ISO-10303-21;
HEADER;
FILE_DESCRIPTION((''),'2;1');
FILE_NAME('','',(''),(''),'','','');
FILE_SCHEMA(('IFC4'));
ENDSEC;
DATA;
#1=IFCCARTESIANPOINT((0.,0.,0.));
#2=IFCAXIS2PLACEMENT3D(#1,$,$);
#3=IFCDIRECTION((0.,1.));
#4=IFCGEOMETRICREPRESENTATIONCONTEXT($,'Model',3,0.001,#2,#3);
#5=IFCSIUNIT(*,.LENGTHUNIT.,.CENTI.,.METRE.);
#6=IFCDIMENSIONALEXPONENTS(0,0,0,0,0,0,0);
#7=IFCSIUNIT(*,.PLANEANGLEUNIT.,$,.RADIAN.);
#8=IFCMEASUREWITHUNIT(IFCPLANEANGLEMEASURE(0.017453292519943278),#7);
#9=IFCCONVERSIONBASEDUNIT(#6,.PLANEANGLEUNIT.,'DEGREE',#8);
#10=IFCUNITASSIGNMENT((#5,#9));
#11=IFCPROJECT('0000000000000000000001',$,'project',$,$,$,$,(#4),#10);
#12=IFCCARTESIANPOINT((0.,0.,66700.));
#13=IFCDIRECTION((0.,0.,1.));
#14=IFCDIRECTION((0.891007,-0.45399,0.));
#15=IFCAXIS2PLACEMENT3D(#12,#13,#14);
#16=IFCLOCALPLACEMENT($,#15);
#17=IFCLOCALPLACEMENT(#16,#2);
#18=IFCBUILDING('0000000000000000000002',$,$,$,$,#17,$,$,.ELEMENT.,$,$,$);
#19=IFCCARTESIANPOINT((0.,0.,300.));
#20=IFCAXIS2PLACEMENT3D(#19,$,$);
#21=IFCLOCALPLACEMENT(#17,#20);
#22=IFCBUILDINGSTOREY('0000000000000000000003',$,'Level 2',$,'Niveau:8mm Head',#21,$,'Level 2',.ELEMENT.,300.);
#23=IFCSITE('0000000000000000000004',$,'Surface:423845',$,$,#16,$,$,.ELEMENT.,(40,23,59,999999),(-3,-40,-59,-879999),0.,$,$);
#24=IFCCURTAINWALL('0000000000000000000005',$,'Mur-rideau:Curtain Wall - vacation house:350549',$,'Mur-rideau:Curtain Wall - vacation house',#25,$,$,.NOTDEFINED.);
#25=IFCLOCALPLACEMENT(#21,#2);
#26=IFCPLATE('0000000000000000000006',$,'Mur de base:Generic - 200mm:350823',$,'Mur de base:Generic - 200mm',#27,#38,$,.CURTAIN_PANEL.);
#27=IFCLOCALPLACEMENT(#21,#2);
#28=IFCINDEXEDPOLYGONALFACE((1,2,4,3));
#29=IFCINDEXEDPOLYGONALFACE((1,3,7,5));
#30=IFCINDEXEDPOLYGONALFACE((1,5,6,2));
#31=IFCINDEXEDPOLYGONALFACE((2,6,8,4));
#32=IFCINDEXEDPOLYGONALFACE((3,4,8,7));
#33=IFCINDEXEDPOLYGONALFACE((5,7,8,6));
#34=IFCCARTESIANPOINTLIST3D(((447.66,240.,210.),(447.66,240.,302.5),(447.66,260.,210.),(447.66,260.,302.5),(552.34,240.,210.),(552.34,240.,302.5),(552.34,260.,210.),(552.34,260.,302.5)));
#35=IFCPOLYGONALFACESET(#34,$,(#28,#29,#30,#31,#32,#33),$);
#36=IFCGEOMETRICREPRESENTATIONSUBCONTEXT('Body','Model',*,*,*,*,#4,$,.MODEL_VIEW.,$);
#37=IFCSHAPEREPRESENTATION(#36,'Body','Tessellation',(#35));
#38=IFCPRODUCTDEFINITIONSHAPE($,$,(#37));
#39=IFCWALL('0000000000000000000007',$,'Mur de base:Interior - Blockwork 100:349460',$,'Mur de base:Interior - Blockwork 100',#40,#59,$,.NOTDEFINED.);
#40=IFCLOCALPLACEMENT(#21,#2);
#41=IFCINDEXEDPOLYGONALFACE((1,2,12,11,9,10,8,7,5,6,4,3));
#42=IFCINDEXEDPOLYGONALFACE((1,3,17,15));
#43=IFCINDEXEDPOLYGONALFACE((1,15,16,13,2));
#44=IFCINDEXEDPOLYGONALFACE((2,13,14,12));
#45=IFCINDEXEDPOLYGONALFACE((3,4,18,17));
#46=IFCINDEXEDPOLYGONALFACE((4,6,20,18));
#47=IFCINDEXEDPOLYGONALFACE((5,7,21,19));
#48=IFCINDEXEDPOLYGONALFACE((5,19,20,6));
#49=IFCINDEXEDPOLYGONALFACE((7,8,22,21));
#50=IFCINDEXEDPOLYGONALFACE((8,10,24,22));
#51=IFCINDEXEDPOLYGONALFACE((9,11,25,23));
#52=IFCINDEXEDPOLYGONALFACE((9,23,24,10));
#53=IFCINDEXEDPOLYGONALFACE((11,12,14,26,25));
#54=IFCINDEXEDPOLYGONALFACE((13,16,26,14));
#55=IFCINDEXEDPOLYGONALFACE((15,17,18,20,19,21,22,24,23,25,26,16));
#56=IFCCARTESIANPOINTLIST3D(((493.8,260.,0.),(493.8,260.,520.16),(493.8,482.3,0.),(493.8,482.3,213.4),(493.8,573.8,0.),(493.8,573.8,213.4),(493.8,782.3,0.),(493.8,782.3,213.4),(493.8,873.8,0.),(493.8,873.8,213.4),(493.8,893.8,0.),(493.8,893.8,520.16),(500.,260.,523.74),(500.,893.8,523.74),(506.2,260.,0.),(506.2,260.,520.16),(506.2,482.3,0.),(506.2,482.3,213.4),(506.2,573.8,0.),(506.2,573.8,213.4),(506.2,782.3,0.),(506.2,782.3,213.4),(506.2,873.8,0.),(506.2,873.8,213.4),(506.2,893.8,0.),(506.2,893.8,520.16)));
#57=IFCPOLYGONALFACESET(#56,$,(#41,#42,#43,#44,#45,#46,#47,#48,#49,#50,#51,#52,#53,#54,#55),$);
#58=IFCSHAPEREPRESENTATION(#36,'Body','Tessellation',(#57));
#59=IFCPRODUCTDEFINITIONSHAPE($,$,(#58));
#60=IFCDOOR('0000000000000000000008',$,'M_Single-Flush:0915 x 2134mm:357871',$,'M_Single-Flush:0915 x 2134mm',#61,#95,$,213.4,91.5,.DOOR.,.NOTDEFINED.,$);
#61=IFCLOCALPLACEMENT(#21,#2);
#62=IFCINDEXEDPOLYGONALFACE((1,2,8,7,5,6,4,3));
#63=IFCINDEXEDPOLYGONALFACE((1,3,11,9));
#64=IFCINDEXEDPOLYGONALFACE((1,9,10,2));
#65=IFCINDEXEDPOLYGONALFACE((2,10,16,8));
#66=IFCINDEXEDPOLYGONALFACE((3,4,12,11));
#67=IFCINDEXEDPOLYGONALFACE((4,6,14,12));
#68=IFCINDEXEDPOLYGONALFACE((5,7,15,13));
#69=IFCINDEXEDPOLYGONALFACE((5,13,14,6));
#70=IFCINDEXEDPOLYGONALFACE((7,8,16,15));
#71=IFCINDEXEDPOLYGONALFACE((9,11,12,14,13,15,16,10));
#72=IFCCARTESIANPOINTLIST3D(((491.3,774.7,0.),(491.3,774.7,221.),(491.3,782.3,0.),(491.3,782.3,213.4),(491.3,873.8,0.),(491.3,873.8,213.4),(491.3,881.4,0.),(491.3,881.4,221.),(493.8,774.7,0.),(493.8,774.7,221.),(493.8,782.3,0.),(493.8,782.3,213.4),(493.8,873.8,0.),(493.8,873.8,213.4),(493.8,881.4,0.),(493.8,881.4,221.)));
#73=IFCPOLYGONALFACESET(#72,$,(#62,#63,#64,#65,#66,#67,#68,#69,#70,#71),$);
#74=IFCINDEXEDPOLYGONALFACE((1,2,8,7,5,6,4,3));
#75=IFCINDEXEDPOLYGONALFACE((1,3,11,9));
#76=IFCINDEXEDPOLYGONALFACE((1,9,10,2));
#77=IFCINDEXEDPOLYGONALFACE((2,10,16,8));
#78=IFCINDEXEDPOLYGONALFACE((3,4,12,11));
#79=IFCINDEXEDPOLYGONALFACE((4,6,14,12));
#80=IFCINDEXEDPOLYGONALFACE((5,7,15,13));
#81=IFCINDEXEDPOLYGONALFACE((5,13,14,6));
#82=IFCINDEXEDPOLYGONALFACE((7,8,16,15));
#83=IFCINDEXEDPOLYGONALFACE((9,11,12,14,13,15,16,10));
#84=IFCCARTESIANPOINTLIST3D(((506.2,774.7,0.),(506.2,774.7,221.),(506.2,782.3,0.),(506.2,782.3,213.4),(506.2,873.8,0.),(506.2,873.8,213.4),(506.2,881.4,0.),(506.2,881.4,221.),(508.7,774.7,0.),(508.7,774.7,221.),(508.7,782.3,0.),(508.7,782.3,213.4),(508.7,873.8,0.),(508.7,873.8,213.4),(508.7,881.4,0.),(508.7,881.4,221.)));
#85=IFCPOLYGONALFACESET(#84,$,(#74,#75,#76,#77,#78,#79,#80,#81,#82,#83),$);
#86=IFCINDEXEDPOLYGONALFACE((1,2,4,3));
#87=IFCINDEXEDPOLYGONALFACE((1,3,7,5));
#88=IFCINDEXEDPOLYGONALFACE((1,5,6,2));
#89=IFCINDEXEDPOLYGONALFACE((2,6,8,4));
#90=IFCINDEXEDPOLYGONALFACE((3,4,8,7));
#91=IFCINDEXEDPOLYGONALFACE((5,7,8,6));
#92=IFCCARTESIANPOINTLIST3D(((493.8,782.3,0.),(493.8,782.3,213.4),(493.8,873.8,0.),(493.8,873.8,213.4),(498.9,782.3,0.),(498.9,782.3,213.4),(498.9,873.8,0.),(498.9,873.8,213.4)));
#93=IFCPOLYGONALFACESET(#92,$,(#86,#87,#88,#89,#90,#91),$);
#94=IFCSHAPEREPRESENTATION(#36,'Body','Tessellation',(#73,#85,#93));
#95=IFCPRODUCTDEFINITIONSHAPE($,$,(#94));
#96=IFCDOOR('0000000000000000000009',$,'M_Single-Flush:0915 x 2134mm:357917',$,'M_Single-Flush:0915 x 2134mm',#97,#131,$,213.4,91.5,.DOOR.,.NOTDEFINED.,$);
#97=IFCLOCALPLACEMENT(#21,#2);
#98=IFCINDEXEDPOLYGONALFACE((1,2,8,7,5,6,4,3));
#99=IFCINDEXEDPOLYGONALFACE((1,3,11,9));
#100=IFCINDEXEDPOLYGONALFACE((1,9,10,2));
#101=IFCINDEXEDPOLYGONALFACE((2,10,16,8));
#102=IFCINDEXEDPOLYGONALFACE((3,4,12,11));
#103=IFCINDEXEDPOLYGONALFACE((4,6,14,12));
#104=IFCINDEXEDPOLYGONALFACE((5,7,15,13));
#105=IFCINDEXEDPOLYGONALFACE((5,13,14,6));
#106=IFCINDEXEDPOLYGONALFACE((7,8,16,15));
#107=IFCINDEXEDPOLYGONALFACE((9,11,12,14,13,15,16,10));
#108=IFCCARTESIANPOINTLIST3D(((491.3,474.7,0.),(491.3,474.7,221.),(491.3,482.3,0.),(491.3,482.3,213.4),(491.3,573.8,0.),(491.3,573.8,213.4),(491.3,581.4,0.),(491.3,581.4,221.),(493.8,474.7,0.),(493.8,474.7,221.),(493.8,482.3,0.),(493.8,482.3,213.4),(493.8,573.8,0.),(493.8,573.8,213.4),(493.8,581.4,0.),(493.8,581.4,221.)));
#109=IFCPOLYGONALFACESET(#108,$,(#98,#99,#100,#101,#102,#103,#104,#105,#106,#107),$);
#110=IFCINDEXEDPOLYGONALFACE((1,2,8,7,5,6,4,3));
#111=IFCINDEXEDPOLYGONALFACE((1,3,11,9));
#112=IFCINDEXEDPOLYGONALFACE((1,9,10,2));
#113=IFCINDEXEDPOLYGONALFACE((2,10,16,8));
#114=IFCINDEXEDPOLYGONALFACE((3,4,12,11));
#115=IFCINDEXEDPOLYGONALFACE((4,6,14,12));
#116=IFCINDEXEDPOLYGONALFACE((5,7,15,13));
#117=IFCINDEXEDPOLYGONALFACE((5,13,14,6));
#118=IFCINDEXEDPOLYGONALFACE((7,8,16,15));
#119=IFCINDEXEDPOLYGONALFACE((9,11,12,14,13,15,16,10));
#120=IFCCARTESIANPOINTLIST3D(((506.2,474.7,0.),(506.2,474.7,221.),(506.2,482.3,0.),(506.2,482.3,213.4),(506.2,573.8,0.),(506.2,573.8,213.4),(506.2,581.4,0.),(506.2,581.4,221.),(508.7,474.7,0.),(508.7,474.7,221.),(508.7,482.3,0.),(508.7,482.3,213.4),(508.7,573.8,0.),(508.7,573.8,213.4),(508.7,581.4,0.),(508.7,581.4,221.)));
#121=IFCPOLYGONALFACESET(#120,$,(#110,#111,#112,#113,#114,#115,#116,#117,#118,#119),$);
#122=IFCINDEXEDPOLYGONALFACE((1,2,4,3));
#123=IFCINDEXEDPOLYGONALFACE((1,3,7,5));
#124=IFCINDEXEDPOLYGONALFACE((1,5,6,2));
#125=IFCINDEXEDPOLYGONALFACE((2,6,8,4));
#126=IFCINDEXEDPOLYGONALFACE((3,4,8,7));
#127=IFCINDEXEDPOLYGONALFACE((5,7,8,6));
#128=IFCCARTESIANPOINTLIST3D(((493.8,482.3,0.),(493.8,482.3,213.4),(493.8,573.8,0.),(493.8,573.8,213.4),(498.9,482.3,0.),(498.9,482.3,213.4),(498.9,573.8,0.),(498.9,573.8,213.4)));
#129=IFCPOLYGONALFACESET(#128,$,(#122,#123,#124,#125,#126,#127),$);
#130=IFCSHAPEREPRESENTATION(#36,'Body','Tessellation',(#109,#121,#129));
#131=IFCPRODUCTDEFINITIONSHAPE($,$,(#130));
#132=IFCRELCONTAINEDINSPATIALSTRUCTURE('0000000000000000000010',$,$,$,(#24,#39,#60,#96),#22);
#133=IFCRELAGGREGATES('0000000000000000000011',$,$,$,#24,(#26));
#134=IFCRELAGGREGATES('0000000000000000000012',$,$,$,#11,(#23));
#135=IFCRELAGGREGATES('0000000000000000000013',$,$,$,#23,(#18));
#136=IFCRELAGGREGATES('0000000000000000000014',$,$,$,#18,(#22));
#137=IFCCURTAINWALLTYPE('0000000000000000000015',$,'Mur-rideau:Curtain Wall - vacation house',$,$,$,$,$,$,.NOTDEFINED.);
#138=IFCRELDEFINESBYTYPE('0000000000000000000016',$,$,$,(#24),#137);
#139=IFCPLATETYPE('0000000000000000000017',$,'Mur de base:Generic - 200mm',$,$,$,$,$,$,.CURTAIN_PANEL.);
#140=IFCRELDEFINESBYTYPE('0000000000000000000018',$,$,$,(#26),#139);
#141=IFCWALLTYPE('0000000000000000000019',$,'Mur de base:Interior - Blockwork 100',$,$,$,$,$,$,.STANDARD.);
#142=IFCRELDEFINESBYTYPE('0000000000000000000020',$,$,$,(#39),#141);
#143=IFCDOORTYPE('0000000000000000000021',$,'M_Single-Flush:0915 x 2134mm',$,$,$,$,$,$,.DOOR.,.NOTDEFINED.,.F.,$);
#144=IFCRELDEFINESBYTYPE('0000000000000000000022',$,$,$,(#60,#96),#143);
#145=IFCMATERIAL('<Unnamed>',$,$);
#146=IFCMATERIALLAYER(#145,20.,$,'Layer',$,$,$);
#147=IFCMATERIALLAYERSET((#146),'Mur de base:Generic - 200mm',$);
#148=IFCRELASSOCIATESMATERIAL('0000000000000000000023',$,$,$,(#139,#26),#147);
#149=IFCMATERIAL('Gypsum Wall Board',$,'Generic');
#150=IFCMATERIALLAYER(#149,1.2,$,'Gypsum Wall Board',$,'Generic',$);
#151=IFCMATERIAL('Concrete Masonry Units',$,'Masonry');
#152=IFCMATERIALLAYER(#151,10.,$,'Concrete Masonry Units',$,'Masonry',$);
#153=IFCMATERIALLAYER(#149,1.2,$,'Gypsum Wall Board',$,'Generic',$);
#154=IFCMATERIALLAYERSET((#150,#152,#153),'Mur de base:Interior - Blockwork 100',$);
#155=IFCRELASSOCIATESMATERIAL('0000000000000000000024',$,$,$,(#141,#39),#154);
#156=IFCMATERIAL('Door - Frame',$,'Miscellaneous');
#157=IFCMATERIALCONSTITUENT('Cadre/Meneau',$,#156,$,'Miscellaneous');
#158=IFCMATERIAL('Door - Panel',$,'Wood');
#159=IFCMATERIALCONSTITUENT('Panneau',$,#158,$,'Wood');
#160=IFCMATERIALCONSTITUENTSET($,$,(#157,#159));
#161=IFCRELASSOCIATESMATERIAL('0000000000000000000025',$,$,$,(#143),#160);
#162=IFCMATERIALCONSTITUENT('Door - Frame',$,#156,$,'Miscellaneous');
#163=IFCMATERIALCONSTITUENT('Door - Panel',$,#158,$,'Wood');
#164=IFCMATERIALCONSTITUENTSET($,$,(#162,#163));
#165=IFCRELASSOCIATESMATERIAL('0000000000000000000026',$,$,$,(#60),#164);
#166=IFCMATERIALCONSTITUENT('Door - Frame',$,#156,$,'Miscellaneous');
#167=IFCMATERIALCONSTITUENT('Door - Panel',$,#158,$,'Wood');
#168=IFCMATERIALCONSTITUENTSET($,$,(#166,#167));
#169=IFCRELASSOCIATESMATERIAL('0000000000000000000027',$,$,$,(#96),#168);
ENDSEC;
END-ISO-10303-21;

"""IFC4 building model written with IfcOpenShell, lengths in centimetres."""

from ifc_helpers import new_model, entity, si_unit, converted_unit, direction, frame, frame_2d, origin, origin_2d_with_axis, place, context, subcontext, project, spatial, polyline, rectangle, outline, extrude, clip, bounded_halfspace, source, transform, mapped, material, layer, layer_set, layer_usage, constituent, constituent_set, type_object, type_shapes, element, fill, aggregate, save


model = new_model("IFC4")

# Units and contexts
model_context = context("Model", 3, precision=0.001, world=origin(), true_north=direction((0.0, 1.0)))
body_context = subcontext(model_context, "Body", "Model", "MODEL_VIEW")
ifc_project = project(units=[si_unit("LENGTHUNIT", "METRE", prefix="CENTI"), converted_unit("PLANEANGLEUNIT", "DEGREE", entity("IfcPlaneAngleMeasure", 0.017453292519943278), si_unit("PLANEANGLEUNIT", "RADIAN"), dimensions=[0, 0, 0, 0, 0, 0, 0])], contexts=[model_context])

# Site, building, storey
site_placement = place(None, frame((0.0, 0.0, 66700.0), z_axis=(0.0, 0.0, 1.0), x_axis=(0.891007, -0.45399, 0.0)))
site = spatial("IfcSite", under=ifc_project, at=site_placement, Name="Surface:423845", CompositionType="ELEMENT", RefLatitude=(40, 23, 59, 999999), RefLongitude=(-3, -40, -59, -879999), RefElevation=0.0)
building_placement = place(site_placement, origin())
building = spatial("IfcBuilding", under=site, at=building_placement, CompositionType="ELEMENT")
storey_placement = place(building_placement, frame((0.0, 0.0, 300.0)))
storey = spatial("IfcBuildingStorey", under=building, at=storey_placement, Name="Level 2", ObjectType="Niveau:8mm Head", LongName="Level 2", CompositionType="ELEMENT", Elevation=300.0)

# Curtain wall
curtain_wall_type = type_object("IfcCurtainWallType", Name="Mur-rideau:Curtain Wall - vacation house", PredefinedType="NOTDEFINED")
curtain_wall_placement = place(storey_placement, frame((0.0, 0.0, -300.0)))
curtain_wall = element("IfcCurtainWall", 1, at=curtain_wall_placement, inside=storey, type_object=curtain_wall_type, Name="Mur-rideau:Curtain Wall - vacation house:350549", ObjectType="Mur-rideau:Curtain Wall - vacation house", PredefinedType="NOTDEFINED")

# Plate
ifc_material_1 = material(Name="<Unnamed>")
ifc_layer_1 = layer(ifc_material_1, 20.0, Name="Layer")
ifc_layer_set_1 = layer_set([ifc_layer_1], Name="Mur de base:Generic - 200mm")
plate_type_1 = type_object("IfcPlateType", Name="Mur de base:Generic - 200mm", PredefinedType="CURTAIN_PANEL", material=ifc_layer_set_1)
ifc_layer_usage_1 = layer_usage(ifc_layer_set_1, "AXIS2", "NEGATIVE", 10.0)
plate_1_placement = place(storey_placement, frame((552.34, 250.0, 210.0), z_axis=(0.0, 0.0, 1.0), x_axis=(-1.0, 0.0, 0.0)))
plate_1 = element("IfcPlate", 2, at=plate_1_placement, type_object=plate_type_1, material=ifc_layer_usage_1, Name="Mur de base:Generic - 200mm:350823", ObjectType="Mur de base:Generic - 200mm", PredefinedType="CURTAIN_PANEL", context=body_context, shape_type="SweptSolid", body=[
    extrude(rectangle(XDim=20.0, YDim=104.69, at=origin_2d_with_axis()), frame((52.34, 0.0, 0.0), z_axis=(0.0, 0.0, 1.0), x_axis=(0.0, 1.0, 0.0)), (0.0, 0.0, 1.0), 92.5),
])

# Wall, openings, doors
ifc_material_2 = material(Name="Gypsum Wall Board", Category="Generic")
ifc_layer_2 = layer(ifc_material_2, 1.2, Name="Gypsum Wall Board", Category="Generic")
ifc_material_3 = material(Name="Concrete Masonry Units", Category="Masonry")
ifc_layer_3 = layer(ifc_material_3, 10.0, Name="Concrete Masonry Units", Category="Masonry")
ifc_layer_4 = layer(ifc_material_2, 1.2, Name="Gypsum Wall Board", Category="Generic")
ifc_layer_set_2 = layer_set([ifc_layer_2, ifc_layer_3, ifc_layer_4], Name="Mur de base:Interior - Blockwork 100")
ifc_layer_usage_2 = layer_usage(ifc_layer_set_2, "AXIS2", "NEGATIVE", 6.2)
wall_type = type_object("IfcWallType", Name="Mur de base:Interior - Blockwork 100", PredefinedType="STANDARD", material=ifc_layer_set_2)
wall_placement = place(storey_placement, frame((500.0, 260.0, 0.0), z_axis=(0.0, 0.0, 1.0), x_axis=(0.0, 1.0, 0.0)))
wall = element("IfcWall", 3, at=wall_placement, inside=storey, type_object=wall_type, material=ifc_layer_usage_2, Name="Mur de base:Interior - Blockwork 100:349460", ObjectType="Mur de base:Interior - Blockwork 100", PredefinedType="NOTDEFINED", context=body_context, shape_type="Clipping", body=[
    clip(clip(extrude(rectangle(XDim=633.8, YDim=12.4, at=frame_2d((316.9, 0.0), x_axis=(-1.0, 0.0))), origin(), (0.0, 0.0, 1.0), 523.74), bounded_halfspace(frame((633.8, 0.0, 523.74), z_axis=(0.0, 0.5, 0.866025), x_axis=(-1.0, 0.0, 0.0)), False, frame((633.8, 0.0, 523.74)), polyline([(0.0, 0.0), (0.0, 6.2), (-287.6, 6.2), (-300.0, 6.2), (-633.8, 6.2), (-633.8, 0.0), (0.0, 0.0)]))), bounded_halfspace(frame((0.0, -6.2, 520.16), z_axis=(0.0, -0.5, 0.866025), x_axis=(1.0, 0.0, 0.0)), False, frame((0.0, -6.2, 520.16)), polyline([(0.0, 0.0), (633.8, 0.0), (633.8, 6.2), (0.0, 6.2), (0.0, 0.0)]))),
])
opening_1_placement = place(wall_placement, frame((522.3, -6.2, 0.0)))
opening_1 = element("IfcOpeningElement", 4, at=opening_1_placement, cuts=wall, PredefinedType="OPENING", context=body_context, shape_type="SweptSolid", body=[
    extrude(rectangle(XDim=91.5, YDim=213.4, at=frame_2d((106.7, 45.75), x_axis=(0.0, 1.0))), frame((0.0, 0.0, 0.0), z_axis=(0.0, 1.0, 0.0), x_axis=(0.0, 0.0, 1.0)), (0.0, 0.0, 1.0), 12.4),
])
opening_2_placement = place(wall_placement, frame((222.3, -6.2, 0.0)))
opening_2 = element("IfcOpeningElement", 5, at=opening_2_placement, cuts=wall, PredefinedType="OPENING", context=body_context, shape_type="SweptSolid", body=[
    extrude(rectangle(XDim=91.5, YDim=213.4, at=frame_2d((106.7, 45.75), x_axis=(0.0, 1.0))), frame((0.0, 0.0, 0.0), z_axis=(0.0, 1.0, 0.0), x_axis=(0.0, 0.0, 1.0)), (0.0, 0.0, 1.0), 12.4),
])
ifc_material_4 = material(Name="Door - Frame", Category="Miscellaneous")
ifc_constituent_1 = constituent(ifc_material_4, Name="Door - Frame", Category="Miscellaneous")
ifc_material_5 = material(Name="Door - Panel", Category="Wood")
ifc_constituent_2 = constituent(ifc_material_5, Name="Door - Panel", Category="Wood")
ifc_constituent_set_1 = constituent_set(constituents=[ifc_constituent_1, ifc_constituent_2])
ifc_constituent_3 = constituent(ifc_material_4, Name="Cadre/Meneau", Category="Miscellaneous")
ifc_constituent_4 = constituent(ifc_material_5, Name="Panneau", Category="Wood")
ifc_constituent_set_2 = constituent_set(constituents=[ifc_constituent_3, ifc_constituent_4])
door_type_1 = type_object("IfcDoorType", Name="M_Single-Flush:0915 x 2134mm", OperationType="NOTDEFINED", ParameterTakesPrecedence=False, PredefinedType="DOOR", material=ifc_constituent_set_2)
shared_shape_1 = source(origin(), body_context, "Body", "SweptSolid", [
    extrude(outline(polyline([(-53.35, -112.4), (53.35, -112.4), (53.35, 108.6), (45.75, 108.6), (45.75, -104.8), (-45.75, -104.8), (-45.75, 108.6), (-53.35, 108.6), (-53.35, -112.4)])), frame((45.75, 12.4, 108.6), z_axis=(0.0, 1.0, 0.0), x_axis=(1.0, 0.0, 0.0)), (0.0, 0.0, 1.0), 2.5),
    extrude(outline(polyline([(-112.4, -53.35), (108.6, -53.35), (108.6, -45.75), (-104.8, -45.75), (-104.8, 45.75), (108.6, 45.75), (108.6, 53.35), (-112.4, 53.35), (-112.4, -53.35)])), frame((45.75, -2.5, 108.6), z_axis=(0.0, 1.0, 0.0), x_axis=(0.0, 0.0, -1.0)), (0.0, 0.0, 1.0), 2.5),
    extrude(rectangle(XDim=5.1, YDim=91.5, at=origin_2d_with_axis()), frame((45.75, 9.85, 0.0), z_axis=(0.0, 0.0, 1.0), x_axis=(0.0, 1.0, 0.0)), (0.0, 0.0, 1.0), 213.4),
])
type_shapes(door_type_1, [shared_shape_1])
door_1_placement = place(opening_1_placement, origin())
door_1 = element("IfcDoor", 6, at=door_1_placement, inside=storey, type_object=door_type_1, material=ifc_constituent_set_1, Name="M_Single-Flush:0915 x 2134mm:357871", ObjectType="M_Single-Flush:0915 x 2134mm", OperationType="NOTDEFINED", OverallHeight=213.4, OverallWidth=91.5, PredefinedType="DOOR", context=body_context, shape_type="MappedRepresentation", body=[
    mapped(shared_shape_1, transform((0.0, 0.0, 0.0), scale=1.0)),
])
fill(opening_1, door_1)
ifc_constituent_5 = constituent(ifc_material_4, Name="Door - Frame", Category="Miscellaneous")
ifc_constituent_6 = constituent(ifc_material_5, Name="Door - Panel", Category="Wood")
ifc_constituent_set_3 = constituent_set(constituents=[ifc_constituent_5, ifc_constituent_6])
door_2_placement = place(opening_2_placement, origin())
door_2 = element("IfcDoor", 7, at=door_2_placement, inside=storey, type_object=door_type_1, material=ifc_constituent_set_3, Name="M_Single-Flush:0915 x 2134mm:357917", ObjectType="M_Single-Flush:0915 x 2134mm", OperationType="NOTDEFINED", OverallHeight=213.4, OverallWidth=91.5, PredefinedType="DOOR", context=body_context, shape_type="MappedRepresentation", body=[
    mapped(shared_shape_1, transform((0.0, 0.0, 0.0), scale=1.0)),
])
fill(opening_2, door_2)

aggregate(curtain_wall, [plate_1])

save(model, "model.ifc")
